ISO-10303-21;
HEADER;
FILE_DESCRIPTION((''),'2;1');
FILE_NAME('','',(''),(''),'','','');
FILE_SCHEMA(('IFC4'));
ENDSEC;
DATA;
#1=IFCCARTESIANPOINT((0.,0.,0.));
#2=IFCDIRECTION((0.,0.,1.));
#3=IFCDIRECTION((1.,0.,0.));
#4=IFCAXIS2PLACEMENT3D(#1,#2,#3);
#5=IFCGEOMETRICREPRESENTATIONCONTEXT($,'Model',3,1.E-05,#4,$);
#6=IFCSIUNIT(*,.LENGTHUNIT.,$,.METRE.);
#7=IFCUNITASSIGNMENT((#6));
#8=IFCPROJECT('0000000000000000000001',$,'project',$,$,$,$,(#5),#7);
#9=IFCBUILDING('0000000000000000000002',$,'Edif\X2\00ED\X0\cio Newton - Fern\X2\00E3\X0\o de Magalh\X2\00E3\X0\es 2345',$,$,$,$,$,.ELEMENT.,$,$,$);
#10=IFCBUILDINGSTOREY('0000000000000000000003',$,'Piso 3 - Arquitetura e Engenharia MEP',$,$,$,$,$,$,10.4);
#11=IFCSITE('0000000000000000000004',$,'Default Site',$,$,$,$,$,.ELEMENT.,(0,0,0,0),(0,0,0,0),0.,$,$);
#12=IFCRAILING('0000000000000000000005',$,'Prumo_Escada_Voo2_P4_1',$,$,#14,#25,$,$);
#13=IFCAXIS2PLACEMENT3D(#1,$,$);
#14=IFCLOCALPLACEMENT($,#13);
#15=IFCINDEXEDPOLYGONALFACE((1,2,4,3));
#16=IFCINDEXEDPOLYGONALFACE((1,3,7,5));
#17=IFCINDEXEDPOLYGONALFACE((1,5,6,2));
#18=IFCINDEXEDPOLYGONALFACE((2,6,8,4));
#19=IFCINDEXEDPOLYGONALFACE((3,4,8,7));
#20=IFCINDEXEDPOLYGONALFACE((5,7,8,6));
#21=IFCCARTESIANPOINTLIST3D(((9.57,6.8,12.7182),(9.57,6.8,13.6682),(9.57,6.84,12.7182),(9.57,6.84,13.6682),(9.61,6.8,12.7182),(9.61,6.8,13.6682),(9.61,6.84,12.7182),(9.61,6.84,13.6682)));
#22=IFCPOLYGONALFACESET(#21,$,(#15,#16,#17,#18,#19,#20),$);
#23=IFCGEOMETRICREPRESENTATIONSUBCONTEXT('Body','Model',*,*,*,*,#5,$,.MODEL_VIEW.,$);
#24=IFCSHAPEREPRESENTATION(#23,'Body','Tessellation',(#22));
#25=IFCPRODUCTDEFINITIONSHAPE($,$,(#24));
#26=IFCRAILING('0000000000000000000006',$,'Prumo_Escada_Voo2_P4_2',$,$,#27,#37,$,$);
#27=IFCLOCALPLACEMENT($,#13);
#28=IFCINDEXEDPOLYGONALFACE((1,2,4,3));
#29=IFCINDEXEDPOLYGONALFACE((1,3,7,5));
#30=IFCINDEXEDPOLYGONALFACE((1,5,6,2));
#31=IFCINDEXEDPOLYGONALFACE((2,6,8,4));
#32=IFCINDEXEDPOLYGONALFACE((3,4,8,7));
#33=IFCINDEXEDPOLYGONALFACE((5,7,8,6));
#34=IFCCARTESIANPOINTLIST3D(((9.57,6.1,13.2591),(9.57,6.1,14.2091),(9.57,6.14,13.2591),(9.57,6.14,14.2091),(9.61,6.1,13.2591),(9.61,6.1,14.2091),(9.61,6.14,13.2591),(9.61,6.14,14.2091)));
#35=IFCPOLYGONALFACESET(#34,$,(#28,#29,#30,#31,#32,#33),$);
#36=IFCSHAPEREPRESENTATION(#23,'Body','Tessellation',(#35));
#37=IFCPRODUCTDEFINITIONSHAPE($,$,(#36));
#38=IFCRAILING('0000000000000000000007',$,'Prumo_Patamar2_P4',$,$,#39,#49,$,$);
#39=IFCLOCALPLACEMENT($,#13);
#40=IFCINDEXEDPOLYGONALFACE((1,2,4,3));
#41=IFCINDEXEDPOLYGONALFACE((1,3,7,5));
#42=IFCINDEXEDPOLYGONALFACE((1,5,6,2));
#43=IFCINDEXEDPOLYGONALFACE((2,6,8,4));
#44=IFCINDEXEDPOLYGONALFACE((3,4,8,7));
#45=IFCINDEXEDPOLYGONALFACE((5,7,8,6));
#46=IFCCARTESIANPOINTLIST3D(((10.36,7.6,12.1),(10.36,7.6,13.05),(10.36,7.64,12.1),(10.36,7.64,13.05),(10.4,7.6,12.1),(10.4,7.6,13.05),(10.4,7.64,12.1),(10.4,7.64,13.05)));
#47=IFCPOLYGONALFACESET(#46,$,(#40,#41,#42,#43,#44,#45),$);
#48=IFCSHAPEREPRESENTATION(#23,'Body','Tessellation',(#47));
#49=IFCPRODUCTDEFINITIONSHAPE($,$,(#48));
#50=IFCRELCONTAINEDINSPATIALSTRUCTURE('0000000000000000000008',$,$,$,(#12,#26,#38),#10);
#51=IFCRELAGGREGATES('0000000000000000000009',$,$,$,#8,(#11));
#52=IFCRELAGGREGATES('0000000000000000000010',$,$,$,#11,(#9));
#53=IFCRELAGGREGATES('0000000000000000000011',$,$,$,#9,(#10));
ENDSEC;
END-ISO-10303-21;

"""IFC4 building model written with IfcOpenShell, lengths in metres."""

from ifc_helpers import new_model, si_unit, frame, frame_2d, origin_with_axes, place, context, subcontext, project, spatial, rectangle, extrude, element, save


model = new_model("IFC4")

# Units and contexts
model_context = context("Model", 3, precision=1e-05, world=origin_with_axes())
body_context = subcontext(model_context, "Body", "Model", "MODEL_VIEW")
ifc_project = project(units=[si_unit("LENGTHUNIT", "METRE")], contexts=[model_context])

# Site, building, storey
site = spatial("IfcSite", under=ifc_project, Name="Default Site", CompositionType="ELEMENT", RefLatitude=(0, 0, 0, 0), RefLongitude=(0, 0, 0, 0), RefElevation=0.0)
building = spatial("IfcBuilding", under=site, Name="Edifício Newton - Fernão de Magalhães 2345", CompositionType="ELEMENT")
storey = spatial("IfcBuildingStorey", under=building, Name="Piso 3 - Arquitetura e Engenharia MEP", Elevation=10.4)

# Railings
for number, where, z_axis, x_axis, name in (
    (1, (9.57, 6.8, 12.7182), (0.0, 0.0, 1.0), (1.0, 0.0, 0.0), "Prumo_Escada_Voo2_P4_1"),
    (2, (9.57, 6.1, 13.2591), (0.0, 0.0, 1.0), (1.0, 0.0, 0.0), "Prumo_Escada_Voo2_P4_2"),
    (3, (10.36, 7.6, 12.1), (0.0, 0.0, 1.0), (1.0, 0.0, 0.0), "Prumo_Patamar2_P4"),
):
    element("IfcRailing", number, at=place(None, frame(where, z_axis=z_axis, x_axis=x_axis)), inside=storey, Name=name, context=body_context, shape_type="SweptSolid", body=[
        extrude(rectangle(XDim=0.04, YDim=0.04, at=frame_2d((0.02, 0.02))), origin_with_axes(), (0.0, 0.0, 1.0), 0.95),
    ])

save(model, "model.ifc")
